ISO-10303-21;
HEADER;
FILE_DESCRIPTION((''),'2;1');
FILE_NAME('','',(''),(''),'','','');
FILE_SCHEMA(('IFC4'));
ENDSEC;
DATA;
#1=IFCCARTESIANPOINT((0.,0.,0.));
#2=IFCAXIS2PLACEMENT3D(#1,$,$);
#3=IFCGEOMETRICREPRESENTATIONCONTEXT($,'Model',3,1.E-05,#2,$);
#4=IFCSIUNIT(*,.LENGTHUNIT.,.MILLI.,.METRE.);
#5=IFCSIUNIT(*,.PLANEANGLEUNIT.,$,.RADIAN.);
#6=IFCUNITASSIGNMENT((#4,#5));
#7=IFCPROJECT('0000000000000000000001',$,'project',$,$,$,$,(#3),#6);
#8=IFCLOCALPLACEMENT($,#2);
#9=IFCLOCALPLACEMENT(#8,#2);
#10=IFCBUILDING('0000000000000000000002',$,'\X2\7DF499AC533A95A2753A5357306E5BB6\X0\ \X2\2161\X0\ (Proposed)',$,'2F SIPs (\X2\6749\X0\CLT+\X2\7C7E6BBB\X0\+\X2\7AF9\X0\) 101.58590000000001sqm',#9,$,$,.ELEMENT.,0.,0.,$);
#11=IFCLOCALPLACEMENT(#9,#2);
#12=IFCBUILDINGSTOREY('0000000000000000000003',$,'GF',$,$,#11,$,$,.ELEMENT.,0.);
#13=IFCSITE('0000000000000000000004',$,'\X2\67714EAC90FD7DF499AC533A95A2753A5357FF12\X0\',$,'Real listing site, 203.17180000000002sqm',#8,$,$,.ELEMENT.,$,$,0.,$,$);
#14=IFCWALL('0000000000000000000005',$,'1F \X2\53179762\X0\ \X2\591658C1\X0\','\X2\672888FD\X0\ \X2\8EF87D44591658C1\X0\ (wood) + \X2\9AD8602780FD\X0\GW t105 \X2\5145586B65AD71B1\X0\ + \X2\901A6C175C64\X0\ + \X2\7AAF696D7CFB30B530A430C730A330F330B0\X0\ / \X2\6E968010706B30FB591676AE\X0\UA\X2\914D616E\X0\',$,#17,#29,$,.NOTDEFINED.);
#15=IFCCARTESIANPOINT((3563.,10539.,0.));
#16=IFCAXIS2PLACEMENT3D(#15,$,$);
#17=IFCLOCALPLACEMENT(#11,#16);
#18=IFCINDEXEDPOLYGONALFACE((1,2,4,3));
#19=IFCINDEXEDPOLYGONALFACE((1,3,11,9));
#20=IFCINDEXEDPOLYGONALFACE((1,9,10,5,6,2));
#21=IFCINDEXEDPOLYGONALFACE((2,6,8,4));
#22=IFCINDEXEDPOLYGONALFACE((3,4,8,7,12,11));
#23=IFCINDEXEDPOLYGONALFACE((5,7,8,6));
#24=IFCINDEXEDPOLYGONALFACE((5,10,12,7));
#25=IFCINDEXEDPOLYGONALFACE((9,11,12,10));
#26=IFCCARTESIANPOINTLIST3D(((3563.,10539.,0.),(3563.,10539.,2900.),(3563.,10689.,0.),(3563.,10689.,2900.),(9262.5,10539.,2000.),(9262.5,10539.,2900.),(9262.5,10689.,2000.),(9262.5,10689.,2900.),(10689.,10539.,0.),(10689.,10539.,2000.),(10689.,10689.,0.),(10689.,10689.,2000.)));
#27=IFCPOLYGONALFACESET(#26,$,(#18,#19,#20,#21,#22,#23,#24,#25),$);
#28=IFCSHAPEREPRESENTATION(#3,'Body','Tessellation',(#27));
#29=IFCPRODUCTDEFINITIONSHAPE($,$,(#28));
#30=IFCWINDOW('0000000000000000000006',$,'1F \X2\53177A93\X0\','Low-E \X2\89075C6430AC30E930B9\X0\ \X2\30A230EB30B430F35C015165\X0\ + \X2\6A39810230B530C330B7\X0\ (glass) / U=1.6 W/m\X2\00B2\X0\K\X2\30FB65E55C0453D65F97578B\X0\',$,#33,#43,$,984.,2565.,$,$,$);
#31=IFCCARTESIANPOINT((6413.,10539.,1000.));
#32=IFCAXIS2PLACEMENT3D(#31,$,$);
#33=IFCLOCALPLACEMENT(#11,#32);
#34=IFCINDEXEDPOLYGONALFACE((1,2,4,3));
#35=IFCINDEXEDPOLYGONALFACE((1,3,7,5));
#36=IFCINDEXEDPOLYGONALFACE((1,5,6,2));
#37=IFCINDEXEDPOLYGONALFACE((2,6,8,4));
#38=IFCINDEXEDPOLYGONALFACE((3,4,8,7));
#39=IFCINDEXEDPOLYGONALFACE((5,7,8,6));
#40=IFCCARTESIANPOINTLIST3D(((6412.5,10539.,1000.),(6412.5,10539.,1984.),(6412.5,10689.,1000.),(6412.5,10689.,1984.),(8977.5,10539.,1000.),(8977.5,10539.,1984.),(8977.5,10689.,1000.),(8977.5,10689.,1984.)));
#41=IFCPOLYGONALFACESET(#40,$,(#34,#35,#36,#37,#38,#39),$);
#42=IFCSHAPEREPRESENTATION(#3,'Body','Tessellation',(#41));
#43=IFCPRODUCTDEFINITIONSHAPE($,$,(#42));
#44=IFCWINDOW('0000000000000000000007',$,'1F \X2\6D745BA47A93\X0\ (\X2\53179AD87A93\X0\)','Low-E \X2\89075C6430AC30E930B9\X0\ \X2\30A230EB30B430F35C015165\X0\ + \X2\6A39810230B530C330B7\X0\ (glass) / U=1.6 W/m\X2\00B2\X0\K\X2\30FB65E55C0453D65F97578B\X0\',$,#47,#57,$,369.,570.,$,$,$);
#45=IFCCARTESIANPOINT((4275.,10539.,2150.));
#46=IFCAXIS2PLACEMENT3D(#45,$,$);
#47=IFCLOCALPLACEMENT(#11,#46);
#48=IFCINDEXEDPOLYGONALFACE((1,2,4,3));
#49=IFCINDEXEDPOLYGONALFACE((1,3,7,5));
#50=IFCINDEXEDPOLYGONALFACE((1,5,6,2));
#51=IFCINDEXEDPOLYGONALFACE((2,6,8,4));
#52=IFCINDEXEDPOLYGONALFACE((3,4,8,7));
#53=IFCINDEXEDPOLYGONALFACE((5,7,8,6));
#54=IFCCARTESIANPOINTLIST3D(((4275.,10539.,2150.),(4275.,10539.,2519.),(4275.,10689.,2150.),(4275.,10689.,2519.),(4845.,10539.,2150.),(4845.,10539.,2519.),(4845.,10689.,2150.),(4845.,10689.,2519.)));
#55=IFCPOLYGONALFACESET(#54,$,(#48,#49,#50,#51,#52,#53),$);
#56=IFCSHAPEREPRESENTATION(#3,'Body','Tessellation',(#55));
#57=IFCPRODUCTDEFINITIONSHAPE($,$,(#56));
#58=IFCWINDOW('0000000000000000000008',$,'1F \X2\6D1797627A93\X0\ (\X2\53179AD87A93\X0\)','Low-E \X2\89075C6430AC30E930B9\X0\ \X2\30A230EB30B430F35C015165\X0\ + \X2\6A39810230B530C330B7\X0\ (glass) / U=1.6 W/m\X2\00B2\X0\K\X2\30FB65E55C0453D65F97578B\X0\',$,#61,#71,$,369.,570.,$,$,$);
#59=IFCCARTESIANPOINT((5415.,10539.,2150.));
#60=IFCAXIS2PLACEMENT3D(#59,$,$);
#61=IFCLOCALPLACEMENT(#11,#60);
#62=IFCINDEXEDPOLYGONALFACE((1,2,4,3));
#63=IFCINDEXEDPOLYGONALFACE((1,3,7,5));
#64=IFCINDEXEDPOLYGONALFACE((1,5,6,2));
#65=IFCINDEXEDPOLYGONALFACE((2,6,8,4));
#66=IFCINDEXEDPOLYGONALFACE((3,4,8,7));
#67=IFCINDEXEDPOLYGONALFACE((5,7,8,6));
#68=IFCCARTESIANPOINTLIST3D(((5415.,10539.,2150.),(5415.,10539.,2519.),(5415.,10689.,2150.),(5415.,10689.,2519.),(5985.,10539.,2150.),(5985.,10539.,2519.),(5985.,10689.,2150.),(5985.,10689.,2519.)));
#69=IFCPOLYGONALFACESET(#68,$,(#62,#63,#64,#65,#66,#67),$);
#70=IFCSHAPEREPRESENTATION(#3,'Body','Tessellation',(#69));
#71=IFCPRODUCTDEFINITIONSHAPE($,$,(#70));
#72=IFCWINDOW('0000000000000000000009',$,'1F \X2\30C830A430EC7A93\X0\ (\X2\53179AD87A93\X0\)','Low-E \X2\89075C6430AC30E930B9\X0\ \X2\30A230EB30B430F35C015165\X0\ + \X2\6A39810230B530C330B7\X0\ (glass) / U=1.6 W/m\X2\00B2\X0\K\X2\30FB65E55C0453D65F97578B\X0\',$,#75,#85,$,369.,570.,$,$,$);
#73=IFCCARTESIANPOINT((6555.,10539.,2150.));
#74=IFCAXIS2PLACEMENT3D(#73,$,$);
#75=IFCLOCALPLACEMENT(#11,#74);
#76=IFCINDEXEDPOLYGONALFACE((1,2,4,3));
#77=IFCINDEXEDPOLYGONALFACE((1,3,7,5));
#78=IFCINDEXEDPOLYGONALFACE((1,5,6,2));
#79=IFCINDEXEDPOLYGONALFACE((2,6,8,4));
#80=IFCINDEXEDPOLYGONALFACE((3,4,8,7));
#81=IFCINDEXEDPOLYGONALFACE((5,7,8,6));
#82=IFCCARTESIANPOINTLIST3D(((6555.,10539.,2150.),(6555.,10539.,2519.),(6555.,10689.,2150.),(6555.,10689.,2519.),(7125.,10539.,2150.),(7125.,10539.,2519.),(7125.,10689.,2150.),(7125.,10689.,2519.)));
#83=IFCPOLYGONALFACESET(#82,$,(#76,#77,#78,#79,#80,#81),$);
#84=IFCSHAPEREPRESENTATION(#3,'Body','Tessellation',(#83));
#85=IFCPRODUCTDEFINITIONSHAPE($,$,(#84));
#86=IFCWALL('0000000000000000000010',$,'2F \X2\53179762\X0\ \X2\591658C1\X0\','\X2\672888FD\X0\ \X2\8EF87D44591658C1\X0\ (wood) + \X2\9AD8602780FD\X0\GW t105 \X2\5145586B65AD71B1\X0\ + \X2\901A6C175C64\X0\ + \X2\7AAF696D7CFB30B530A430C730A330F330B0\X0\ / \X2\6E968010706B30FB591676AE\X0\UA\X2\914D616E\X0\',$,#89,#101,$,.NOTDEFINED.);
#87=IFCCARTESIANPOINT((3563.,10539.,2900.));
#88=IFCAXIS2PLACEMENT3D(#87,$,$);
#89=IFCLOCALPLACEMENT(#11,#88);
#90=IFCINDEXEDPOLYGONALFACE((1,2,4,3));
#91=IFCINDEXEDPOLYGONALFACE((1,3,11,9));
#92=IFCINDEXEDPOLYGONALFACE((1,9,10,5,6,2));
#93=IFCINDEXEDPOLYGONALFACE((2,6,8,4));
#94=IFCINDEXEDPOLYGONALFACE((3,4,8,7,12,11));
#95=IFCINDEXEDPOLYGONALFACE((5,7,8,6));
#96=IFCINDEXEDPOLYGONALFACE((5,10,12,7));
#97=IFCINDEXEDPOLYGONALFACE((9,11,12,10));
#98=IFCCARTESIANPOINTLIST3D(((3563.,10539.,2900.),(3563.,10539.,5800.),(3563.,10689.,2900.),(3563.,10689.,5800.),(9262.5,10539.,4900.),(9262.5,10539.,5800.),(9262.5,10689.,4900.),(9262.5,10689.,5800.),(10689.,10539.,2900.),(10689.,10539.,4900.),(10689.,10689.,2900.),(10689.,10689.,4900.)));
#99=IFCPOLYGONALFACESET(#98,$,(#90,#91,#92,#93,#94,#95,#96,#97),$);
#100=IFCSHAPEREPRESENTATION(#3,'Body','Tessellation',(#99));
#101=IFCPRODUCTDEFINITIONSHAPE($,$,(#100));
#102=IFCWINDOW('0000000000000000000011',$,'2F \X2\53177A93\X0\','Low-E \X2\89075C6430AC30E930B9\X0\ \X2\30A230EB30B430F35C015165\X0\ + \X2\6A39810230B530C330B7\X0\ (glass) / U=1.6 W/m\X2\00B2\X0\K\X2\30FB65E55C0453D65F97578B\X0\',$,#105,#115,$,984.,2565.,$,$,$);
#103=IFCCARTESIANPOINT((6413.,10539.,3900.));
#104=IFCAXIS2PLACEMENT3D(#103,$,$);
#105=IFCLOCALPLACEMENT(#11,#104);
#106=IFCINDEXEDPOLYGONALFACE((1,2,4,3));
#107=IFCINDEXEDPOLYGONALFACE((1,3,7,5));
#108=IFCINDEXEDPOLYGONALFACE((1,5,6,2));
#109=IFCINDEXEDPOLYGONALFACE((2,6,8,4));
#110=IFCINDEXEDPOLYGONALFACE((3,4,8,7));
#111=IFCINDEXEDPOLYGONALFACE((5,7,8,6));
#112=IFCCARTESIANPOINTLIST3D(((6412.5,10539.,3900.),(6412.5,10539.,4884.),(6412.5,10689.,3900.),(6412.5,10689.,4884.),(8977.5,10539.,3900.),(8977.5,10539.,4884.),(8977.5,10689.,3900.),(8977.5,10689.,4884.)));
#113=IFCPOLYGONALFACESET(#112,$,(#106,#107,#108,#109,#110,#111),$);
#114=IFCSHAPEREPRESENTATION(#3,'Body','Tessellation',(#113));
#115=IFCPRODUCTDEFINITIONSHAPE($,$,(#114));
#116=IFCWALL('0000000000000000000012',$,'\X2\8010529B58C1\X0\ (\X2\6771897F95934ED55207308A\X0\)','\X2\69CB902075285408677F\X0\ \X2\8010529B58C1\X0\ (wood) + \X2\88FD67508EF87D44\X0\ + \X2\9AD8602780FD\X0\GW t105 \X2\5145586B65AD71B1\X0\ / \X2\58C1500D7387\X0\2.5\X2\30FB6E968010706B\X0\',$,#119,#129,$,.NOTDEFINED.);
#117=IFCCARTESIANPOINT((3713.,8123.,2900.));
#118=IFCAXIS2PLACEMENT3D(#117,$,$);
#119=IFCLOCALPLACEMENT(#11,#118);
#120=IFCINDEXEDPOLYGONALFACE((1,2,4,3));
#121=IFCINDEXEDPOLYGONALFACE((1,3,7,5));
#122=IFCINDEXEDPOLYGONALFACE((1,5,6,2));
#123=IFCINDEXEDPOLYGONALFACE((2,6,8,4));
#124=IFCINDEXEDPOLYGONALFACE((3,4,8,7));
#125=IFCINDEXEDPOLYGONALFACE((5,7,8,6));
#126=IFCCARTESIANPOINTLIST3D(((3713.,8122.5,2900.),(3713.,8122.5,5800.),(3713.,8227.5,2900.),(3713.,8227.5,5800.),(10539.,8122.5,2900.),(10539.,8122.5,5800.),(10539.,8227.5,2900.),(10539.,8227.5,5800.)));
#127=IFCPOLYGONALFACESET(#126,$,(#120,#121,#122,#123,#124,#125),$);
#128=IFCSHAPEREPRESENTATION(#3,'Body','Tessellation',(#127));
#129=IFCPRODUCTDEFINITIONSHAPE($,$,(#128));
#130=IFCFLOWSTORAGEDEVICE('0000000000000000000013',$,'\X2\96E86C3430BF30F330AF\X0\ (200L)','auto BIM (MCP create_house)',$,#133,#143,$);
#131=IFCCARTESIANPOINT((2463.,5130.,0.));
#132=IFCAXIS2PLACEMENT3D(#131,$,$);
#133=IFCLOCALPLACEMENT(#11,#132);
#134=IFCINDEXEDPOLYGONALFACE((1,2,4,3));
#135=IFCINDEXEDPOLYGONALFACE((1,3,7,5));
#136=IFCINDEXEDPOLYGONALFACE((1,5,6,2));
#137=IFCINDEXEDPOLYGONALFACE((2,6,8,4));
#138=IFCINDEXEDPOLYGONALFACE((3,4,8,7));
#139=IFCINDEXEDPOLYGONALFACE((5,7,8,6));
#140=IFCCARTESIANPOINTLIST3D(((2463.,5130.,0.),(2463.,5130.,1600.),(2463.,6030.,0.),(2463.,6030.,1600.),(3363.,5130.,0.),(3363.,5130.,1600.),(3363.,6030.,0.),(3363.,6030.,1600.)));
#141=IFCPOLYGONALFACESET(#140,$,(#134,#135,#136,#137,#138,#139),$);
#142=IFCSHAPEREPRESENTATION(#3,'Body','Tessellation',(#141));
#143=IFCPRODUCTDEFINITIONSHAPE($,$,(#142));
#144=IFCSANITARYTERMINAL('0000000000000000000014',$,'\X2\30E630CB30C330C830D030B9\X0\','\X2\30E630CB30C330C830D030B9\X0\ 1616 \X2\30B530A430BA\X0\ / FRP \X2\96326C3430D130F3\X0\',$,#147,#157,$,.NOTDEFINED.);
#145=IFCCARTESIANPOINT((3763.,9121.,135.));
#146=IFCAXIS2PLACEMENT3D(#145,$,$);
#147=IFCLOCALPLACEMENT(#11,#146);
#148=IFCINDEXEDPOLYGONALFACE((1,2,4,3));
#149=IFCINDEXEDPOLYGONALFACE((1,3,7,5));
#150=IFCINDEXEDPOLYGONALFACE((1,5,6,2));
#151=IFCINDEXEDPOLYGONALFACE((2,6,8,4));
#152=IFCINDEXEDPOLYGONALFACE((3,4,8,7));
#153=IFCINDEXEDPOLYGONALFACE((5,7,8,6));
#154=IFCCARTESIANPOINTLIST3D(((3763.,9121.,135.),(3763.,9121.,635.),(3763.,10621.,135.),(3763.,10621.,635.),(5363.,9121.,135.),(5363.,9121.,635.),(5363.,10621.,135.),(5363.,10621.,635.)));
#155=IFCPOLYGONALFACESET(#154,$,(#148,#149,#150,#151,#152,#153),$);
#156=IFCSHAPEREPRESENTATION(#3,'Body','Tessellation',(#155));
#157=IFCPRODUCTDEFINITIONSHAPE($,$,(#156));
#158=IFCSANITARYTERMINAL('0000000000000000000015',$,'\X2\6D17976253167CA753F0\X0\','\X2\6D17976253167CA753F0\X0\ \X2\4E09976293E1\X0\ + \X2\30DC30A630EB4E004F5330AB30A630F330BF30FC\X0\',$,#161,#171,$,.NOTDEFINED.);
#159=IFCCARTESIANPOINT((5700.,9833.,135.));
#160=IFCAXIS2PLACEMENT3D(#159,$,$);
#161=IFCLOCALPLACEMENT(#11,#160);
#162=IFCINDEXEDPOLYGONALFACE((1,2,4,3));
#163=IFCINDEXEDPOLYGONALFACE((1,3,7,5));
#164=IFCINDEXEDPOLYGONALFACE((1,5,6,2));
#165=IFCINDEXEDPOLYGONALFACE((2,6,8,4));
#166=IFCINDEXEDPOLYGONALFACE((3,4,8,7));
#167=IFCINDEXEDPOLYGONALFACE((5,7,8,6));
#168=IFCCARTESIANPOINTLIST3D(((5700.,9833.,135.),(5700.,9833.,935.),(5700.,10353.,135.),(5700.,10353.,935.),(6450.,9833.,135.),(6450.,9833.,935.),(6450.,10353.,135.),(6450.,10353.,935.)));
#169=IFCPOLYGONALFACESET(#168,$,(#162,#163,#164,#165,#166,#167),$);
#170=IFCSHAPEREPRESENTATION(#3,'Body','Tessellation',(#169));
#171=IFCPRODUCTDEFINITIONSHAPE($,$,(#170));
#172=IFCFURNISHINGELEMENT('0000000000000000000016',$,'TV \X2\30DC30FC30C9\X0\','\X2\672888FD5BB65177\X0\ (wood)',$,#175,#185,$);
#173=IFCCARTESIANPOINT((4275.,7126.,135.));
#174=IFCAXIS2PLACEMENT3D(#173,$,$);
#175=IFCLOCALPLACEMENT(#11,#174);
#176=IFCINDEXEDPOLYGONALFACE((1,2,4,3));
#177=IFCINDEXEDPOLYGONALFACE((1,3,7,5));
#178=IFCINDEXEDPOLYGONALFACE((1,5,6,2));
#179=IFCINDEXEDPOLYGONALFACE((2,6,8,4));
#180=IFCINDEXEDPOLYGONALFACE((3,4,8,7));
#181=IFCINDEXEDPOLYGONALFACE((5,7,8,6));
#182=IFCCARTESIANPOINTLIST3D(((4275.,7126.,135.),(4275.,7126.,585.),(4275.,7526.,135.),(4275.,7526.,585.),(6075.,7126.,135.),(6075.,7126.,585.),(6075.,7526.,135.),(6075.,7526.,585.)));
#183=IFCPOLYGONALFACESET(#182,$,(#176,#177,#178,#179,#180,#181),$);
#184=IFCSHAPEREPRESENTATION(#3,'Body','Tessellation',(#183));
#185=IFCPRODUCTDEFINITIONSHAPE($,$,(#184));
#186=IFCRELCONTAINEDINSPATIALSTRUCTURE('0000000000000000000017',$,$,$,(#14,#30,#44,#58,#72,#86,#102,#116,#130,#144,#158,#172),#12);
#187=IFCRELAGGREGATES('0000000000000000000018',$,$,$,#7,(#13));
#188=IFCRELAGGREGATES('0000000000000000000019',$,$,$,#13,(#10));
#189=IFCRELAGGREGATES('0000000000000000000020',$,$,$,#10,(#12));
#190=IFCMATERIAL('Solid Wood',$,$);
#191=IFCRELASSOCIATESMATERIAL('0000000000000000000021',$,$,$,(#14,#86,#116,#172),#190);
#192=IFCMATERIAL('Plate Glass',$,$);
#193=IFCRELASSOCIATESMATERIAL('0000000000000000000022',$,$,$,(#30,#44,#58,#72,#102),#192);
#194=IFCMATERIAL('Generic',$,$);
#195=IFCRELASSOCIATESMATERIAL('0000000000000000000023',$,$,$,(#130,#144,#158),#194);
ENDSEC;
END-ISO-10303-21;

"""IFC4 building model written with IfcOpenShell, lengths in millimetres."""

from ifc_helpers import new_model, si_unit, frame, frame_2d, origin, place, context, project, spatial, rectangle, extrude, material, element, fill, save


model = new_model("IFC4")

# Units and contexts
model_context = context("Model", 3, precision=1e-05, world=origin())
ifc_project = project(units=[si_unit("LENGTHUNIT", "METRE", prefix="MILLI"), si_unit("PLANEANGLEUNIT", "RADIAN")], contexts=[model_context])

# Site, building, storey
site_placement = place(None, origin())
site = spatial("IfcSite", under=ifc_project, at=site_placement, Name="東京都練馬区関町南２", ObjectType="Real listing site, 203.17180000000002sqm", CompositionType="ELEMENT", RefElevation=0.0)
building_placement = place(site_placement, origin())
building = spatial("IfcBuilding", under=site, at=building_placement, Name="練馬区関町南の家 Ⅱ (Proposed)", ObjectType="2F SIPs (杉CLT+籾殻+竹) 101.58590000000001sqm", CompositionType="ELEMENT", ElevationOfRefHeight=0.0, ElevationOfTerrain=0.0)
storey_placement = place(building_placement, origin())
storey = spatial("IfcBuildingStorey", under=building, at=storey_placement, Name="GF", CompositionType="ELEMENT", Elevation=0.0)

# Wall, openings, windows
ifc_material_1 = material(Name="Solid Wood")
wall_1_placement = place(storey_placement, frame((3563.0, 10539.0, 0.0)))
wall_1 = element("IfcWall", 1, at=wall_1_placement, inside=storey, material=ifc_material_1, Name="1F 北面 外壁", Description="木製 軸組外壁 (wood) + 高性能GW t105 充填断熱 + 通気層 + 窯業系サイディング / 準耐火・外皮UA配慮", PredefinedType="NOTDEFINED", context=model_context, shape_type="SweptSolid", body=[
    extrude(rectangle(XDim=7126.0, YDim=150.0, at=frame_2d((3563.0, 75.0))), frame((3563.0, 10539.0, 0.0)), (0.0, 0.0, 1.0), 2900.0),
])
opening_1_placement = place(storey_placement, frame((6413.0, 10539.0, 1000.0)))
opening_1 = element("IfcOpeningElement", 2, at=opening_1_placement, cuts=wall_1, PredefinedType="NOTDEFINED", context=model_context, shape_type="SweptSolid", body=[
    extrude(rectangle(XDim=2565.0, YDim=150.0, at=frame_2d((1282.0, 75.0))), frame((6413.0, 10539.0, 1000.0)), (0.0, 0.0, 1.0), 984.0),
])
opening_2_placement = place(storey_placement, frame((4275.0, 10539.0, 2150.0)))
opening_2 = element("IfcOpeningElement", 3, at=opening_2_placement, cuts=wall_1, PredefinedType="NOTDEFINED", context=model_context, shape_type="SweptSolid", body=[
    extrude(rectangle(XDim=570.0, YDim=150.0, at=frame_2d((285.0, 75.0))), frame((4275.0, 10539.0, 2150.0)), (0.0, 0.0, 1.0), 369.0),
])
opening_3_placement = place(storey_placement, frame((5415.0, 10539.0, 2150.0)))
opening_3 = element("IfcOpeningElement", 4, at=opening_3_placement, cuts=wall_1, PredefinedType="NOTDEFINED", context=model_context, shape_type="SweptSolid", body=[
    extrude(rectangle(XDim=570.0, YDim=150.0, at=frame_2d((285.0, 75.0))), frame((5415.0, 10539.0, 2150.0)), (0.0, 0.0, 1.0), 369.0),
])
opening_4_placement = place(storey_placement, frame((6555.0, 10539.0, 2150.0)))
opening_4 = element("IfcOpeningElement", 5, at=opening_4_placement, cuts=wall_1, PredefinedType="NOTDEFINED", context=model_context, shape_type="SweptSolid", body=[
    extrude(rectangle(XDim=570.0, YDim=150.0, at=frame_2d((285.0, 75.0))), frame((6555.0, 10539.0, 2150.0)), (0.0, 0.0, 1.0), 369.0),
])
ifc_material_2 = material(Name="Plate Glass")
window_1_placement = place(storey_placement, frame((6413.0, 10539.0, 1000.0)))
window_1 = element("IfcWindow", 6, at=window_1_placement, inside=storey, material=ifc_material_2, Name="1F 北窓", Description="Low-E 複層ガラス アルゴン封入 + 樹脂サッシ (glass) / U=1.6 W/m²K・日射取得型", OverallHeight=984.0, OverallWidth=2565.0, context=model_context, shape_type="SweptSolid", body=[
    extrude(rectangle(XDim=2565.0, YDim=150.0, at=frame_2d((1282.0, 75.0))), frame((6413.0, 10539.0, 1000.0)), (0.0, 0.0, 1.0), 984.0),
])
fill(opening_1, window_1)
window_2_placement = place(storey_placement, frame((4275.0, 10539.0, 2150.0)))
window_2 = element("IfcWindow", 7, at=window_2_placement, inside=storey, material=ifc_material_2, Name="1F 浴室窓 (北高窓)", Description="Low-E 複層ガラス アルゴン封入 + 樹脂サッシ (glass) / U=1.6 W/m²K・日射取得型", OverallHeight=369.0, OverallWidth=570.0, context=model_context, shape_type="SweptSolid", body=[
    extrude(rectangle(XDim=570.0, YDim=150.0, at=frame_2d((285.0, 75.0))), frame((4275.0, 10539.0, 2150.0)), (0.0, 0.0, 1.0), 369.0),
])
fill(opening_2, window_2)
window_3_placement = place(storey_placement, frame((5415.0, 10539.0, 2150.0)))
window_3 = element("IfcWindow", 8, at=window_3_placement, inside=storey, material=ifc_material_2, Name="1F 洗面窓 (北高窓)", Description="Low-E 複層ガラス アルゴン封入 + 樹脂サッシ (glass) / U=1.6 W/m²K・日射取得型", OverallHeight=369.0, OverallWidth=570.0, context=model_context, shape_type="SweptSolid", body=[
    extrude(rectangle(XDim=570.0, YDim=150.0, at=frame_2d((285.0, 75.0))), frame((5415.0, 10539.0, 2150.0)), (0.0, 0.0, 1.0), 369.0),
])
fill(opening_3, window_3)
window_4_placement = place(storey_placement, frame((6555.0, 10539.0, 2150.0)))
window_4 = element("IfcWindow", 9, at=window_4_placement, inside=storey, material=ifc_material_2, Name="1F トイレ窓 (北高窓)", Description="Low-E 複層ガラス アルゴン封入 + 樹脂サッシ (glass) / U=1.6 W/m²K・日射取得型", OverallHeight=369.0, OverallWidth=570.0, context=model_context, shape_type="SweptSolid", body=[
    extrude(rectangle(XDim=570.0, YDim=150.0, at=frame_2d((285.0, 75.0))), frame((6555.0, 10539.0, 2150.0)), (0.0, 0.0, 1.0), 369.0),
])
fill(opening_4, window_4)

# Wall, opening, window
wall_2_placement = place(storey_placement, frame((3563.0, 10539.0, 2900.0)))
wall_2 = element("IfcWall", 10, at=wall_2_placement, inside=storey, material=ifc_material_1, Name="2F 北面 外壁", Description="木製 軸組外壁 (wood) + 高性能GW t105 充填断熱 + 通気層 + 窯業系サイディング / 準耐火・外皮UA配慮", PredefinedType="NOTDEFINED", context=model_context, shape_type="SweptSolid", body=[
    extrude(rectangle(XDim=7126.0, YDim=150.0, at=frame_2d((3563.0, 75.0))), frame((3563.0, 10539.0, 2900.0)), (0.0, 0.0, 1.0), 2900.0),
])
opening_5_placement = place(storey_placement, frame((6413.0, 10539.0, 3900.0)))
opening_5 = element("IfcOpeningElement", 11, at=opening_5_placement, cuts=wall_2, PredefinedType="NOTDEFINED", context=model_context, shape_type="SweptSolid", body=[
    extrude(rectangle(XDim=2565.0, YDim=150.0, at=frame_2d((1282.0, 75.0))), frame((6413.0, 10539.0, 3900.0)), (0.0, 0.0, 1.0), 984.0),
])
window_5_placement = place(storey_placement, frame((6413.0, 10539.0, 3900.0)))
window_5 = element("IfcWindow", 12, at=window_5_placement, inside=storey, material=ifc_material_2, Name="2F 北窓", Description="Low-E 複層ガラス アルゴン封入 + 樹脂サッシ (glass) / U=1.6 W/m²K・日射取得型", OverallHeight=984.0, OverallWidth=2565.0, context=model_context, shape_type="SweptSolid", body=[
    extrude(rectangle(XDim=2565.0, YDim=150.0, at=frame_2d((1282.0, 75.0))), frame((6413.0, 10539.0, 3900.0)), (0.0, 0.0, 1.0), 984.0),
])
fill(opening_5, window_5)

# Wall
wall_3_placement = place(storey_placement, frame((3713.0, 8123.0, 2900.0)))
element("IfcWall", 13, at=wall_3_placement, inside=storey, material=ifc_material_1, Name="耐力壁 (東西間仕切り)", Description="構造用合板 耐力壁 (wood) + 製材軸組 + 高性能GW t105 充填断熱 / 壁倍率2.5・準耐火", PredefinedType="NOTDEFINED", context=model_context, shape_type="SweptSolid", body=[
    extrude(rectangle(XDim=6826.0, YDim=105.0, at=frame_2d((3413.0, 52.0))), frame((3713.0, 8123.0, 2900.0)), (0.0, 0.0, 1.0), 2900.0),
])

# Flow storage device
ifc_material_3 = material(Name="Generic")
flow_storage_device_placement = place(storey_placement, frame((2463.0, 5130.0, 0.0)))
element("IfcFlowStorageDevice", 14, at=flow_storage_device_placement, inside=storey, material=ifc_material_3, Name="雨水タンク (200L)", Description="auto BIM (MCP create_house)", context=model_context, shape_type="SweptSolid", body=[
    extrude(rectangle(XDim=900.0, YDim=900.0, at=frame_2d((450.0, 450.0))), frame((2463.0, 5130.0, 0.0)), (0.0, 0.0, 1.0), 1600.0),
])

# Sanitary terminals
sanitary_terminal_1_placement = place(storey_placement, frame((3763.0, 9121.0, 135.0)))
element("IfcSanitaryTerminal", 15, at=sanitary_terminal_1_placement, inside=storey, material=ifc_material_3, Name="ユニットバス", Description="ユニットバス 1616 サイズ / FRP 防水パン", PredefinedType="NOTDEFINED", context=model_context, shape_type="SweptSolid", body=[
    extrude(rectangle(XDim=1600.0, YDim=1500.0, at=frame_2d((800.0, 750.0))), frame((3763.0, 9121.0, 135.0)), (0.0, 0.0, 1.0), 500.0),
])
sanitary_terminal_2_placement = place(storey_placement, frame((5700.0, 9833.0, 135.0)))
element("IfcSanitaryTerminal", 16, at=sanitary_terminal_2_placement, inside=storey, material=ifc_material_3, Name="洗面化粧台", Description="洗面化粧台 三面鏡 + ボウル一体カウンター", PredefinedType="NOTDEFINED", context=model_context, shape_type="SweptSolid", body=[
    extrude(rectangle(XDim=750.0, YDim=520.0, at=frame_2d((375.0, 260.0))), frame((5700.0, 9833.0, 135.0)), (0.0, 0.0, 1.0), 800.0),
])

# Furnishing element
furnishing_1_placement = place(storey_placement, frame((4275.0, 7126.0, 135.0)))
element("IfcFurnishingElement", 17, at=furnishing_1_placement, inside=storey, material=ifc_material_1, Name="TV ボード", Description="木製家具 (wood)", context=model_context, shape_type="SweptSolid", body=[
    extrude(rectangle(XDim=1800.0, YDim=400.0, at=frame_2d((900.0, 200.0))), frame((4275.0, 7126.0, 135.0)), (0.0, 0.0, 1.0), 450.0),
])

save(model, "model.ifc")
